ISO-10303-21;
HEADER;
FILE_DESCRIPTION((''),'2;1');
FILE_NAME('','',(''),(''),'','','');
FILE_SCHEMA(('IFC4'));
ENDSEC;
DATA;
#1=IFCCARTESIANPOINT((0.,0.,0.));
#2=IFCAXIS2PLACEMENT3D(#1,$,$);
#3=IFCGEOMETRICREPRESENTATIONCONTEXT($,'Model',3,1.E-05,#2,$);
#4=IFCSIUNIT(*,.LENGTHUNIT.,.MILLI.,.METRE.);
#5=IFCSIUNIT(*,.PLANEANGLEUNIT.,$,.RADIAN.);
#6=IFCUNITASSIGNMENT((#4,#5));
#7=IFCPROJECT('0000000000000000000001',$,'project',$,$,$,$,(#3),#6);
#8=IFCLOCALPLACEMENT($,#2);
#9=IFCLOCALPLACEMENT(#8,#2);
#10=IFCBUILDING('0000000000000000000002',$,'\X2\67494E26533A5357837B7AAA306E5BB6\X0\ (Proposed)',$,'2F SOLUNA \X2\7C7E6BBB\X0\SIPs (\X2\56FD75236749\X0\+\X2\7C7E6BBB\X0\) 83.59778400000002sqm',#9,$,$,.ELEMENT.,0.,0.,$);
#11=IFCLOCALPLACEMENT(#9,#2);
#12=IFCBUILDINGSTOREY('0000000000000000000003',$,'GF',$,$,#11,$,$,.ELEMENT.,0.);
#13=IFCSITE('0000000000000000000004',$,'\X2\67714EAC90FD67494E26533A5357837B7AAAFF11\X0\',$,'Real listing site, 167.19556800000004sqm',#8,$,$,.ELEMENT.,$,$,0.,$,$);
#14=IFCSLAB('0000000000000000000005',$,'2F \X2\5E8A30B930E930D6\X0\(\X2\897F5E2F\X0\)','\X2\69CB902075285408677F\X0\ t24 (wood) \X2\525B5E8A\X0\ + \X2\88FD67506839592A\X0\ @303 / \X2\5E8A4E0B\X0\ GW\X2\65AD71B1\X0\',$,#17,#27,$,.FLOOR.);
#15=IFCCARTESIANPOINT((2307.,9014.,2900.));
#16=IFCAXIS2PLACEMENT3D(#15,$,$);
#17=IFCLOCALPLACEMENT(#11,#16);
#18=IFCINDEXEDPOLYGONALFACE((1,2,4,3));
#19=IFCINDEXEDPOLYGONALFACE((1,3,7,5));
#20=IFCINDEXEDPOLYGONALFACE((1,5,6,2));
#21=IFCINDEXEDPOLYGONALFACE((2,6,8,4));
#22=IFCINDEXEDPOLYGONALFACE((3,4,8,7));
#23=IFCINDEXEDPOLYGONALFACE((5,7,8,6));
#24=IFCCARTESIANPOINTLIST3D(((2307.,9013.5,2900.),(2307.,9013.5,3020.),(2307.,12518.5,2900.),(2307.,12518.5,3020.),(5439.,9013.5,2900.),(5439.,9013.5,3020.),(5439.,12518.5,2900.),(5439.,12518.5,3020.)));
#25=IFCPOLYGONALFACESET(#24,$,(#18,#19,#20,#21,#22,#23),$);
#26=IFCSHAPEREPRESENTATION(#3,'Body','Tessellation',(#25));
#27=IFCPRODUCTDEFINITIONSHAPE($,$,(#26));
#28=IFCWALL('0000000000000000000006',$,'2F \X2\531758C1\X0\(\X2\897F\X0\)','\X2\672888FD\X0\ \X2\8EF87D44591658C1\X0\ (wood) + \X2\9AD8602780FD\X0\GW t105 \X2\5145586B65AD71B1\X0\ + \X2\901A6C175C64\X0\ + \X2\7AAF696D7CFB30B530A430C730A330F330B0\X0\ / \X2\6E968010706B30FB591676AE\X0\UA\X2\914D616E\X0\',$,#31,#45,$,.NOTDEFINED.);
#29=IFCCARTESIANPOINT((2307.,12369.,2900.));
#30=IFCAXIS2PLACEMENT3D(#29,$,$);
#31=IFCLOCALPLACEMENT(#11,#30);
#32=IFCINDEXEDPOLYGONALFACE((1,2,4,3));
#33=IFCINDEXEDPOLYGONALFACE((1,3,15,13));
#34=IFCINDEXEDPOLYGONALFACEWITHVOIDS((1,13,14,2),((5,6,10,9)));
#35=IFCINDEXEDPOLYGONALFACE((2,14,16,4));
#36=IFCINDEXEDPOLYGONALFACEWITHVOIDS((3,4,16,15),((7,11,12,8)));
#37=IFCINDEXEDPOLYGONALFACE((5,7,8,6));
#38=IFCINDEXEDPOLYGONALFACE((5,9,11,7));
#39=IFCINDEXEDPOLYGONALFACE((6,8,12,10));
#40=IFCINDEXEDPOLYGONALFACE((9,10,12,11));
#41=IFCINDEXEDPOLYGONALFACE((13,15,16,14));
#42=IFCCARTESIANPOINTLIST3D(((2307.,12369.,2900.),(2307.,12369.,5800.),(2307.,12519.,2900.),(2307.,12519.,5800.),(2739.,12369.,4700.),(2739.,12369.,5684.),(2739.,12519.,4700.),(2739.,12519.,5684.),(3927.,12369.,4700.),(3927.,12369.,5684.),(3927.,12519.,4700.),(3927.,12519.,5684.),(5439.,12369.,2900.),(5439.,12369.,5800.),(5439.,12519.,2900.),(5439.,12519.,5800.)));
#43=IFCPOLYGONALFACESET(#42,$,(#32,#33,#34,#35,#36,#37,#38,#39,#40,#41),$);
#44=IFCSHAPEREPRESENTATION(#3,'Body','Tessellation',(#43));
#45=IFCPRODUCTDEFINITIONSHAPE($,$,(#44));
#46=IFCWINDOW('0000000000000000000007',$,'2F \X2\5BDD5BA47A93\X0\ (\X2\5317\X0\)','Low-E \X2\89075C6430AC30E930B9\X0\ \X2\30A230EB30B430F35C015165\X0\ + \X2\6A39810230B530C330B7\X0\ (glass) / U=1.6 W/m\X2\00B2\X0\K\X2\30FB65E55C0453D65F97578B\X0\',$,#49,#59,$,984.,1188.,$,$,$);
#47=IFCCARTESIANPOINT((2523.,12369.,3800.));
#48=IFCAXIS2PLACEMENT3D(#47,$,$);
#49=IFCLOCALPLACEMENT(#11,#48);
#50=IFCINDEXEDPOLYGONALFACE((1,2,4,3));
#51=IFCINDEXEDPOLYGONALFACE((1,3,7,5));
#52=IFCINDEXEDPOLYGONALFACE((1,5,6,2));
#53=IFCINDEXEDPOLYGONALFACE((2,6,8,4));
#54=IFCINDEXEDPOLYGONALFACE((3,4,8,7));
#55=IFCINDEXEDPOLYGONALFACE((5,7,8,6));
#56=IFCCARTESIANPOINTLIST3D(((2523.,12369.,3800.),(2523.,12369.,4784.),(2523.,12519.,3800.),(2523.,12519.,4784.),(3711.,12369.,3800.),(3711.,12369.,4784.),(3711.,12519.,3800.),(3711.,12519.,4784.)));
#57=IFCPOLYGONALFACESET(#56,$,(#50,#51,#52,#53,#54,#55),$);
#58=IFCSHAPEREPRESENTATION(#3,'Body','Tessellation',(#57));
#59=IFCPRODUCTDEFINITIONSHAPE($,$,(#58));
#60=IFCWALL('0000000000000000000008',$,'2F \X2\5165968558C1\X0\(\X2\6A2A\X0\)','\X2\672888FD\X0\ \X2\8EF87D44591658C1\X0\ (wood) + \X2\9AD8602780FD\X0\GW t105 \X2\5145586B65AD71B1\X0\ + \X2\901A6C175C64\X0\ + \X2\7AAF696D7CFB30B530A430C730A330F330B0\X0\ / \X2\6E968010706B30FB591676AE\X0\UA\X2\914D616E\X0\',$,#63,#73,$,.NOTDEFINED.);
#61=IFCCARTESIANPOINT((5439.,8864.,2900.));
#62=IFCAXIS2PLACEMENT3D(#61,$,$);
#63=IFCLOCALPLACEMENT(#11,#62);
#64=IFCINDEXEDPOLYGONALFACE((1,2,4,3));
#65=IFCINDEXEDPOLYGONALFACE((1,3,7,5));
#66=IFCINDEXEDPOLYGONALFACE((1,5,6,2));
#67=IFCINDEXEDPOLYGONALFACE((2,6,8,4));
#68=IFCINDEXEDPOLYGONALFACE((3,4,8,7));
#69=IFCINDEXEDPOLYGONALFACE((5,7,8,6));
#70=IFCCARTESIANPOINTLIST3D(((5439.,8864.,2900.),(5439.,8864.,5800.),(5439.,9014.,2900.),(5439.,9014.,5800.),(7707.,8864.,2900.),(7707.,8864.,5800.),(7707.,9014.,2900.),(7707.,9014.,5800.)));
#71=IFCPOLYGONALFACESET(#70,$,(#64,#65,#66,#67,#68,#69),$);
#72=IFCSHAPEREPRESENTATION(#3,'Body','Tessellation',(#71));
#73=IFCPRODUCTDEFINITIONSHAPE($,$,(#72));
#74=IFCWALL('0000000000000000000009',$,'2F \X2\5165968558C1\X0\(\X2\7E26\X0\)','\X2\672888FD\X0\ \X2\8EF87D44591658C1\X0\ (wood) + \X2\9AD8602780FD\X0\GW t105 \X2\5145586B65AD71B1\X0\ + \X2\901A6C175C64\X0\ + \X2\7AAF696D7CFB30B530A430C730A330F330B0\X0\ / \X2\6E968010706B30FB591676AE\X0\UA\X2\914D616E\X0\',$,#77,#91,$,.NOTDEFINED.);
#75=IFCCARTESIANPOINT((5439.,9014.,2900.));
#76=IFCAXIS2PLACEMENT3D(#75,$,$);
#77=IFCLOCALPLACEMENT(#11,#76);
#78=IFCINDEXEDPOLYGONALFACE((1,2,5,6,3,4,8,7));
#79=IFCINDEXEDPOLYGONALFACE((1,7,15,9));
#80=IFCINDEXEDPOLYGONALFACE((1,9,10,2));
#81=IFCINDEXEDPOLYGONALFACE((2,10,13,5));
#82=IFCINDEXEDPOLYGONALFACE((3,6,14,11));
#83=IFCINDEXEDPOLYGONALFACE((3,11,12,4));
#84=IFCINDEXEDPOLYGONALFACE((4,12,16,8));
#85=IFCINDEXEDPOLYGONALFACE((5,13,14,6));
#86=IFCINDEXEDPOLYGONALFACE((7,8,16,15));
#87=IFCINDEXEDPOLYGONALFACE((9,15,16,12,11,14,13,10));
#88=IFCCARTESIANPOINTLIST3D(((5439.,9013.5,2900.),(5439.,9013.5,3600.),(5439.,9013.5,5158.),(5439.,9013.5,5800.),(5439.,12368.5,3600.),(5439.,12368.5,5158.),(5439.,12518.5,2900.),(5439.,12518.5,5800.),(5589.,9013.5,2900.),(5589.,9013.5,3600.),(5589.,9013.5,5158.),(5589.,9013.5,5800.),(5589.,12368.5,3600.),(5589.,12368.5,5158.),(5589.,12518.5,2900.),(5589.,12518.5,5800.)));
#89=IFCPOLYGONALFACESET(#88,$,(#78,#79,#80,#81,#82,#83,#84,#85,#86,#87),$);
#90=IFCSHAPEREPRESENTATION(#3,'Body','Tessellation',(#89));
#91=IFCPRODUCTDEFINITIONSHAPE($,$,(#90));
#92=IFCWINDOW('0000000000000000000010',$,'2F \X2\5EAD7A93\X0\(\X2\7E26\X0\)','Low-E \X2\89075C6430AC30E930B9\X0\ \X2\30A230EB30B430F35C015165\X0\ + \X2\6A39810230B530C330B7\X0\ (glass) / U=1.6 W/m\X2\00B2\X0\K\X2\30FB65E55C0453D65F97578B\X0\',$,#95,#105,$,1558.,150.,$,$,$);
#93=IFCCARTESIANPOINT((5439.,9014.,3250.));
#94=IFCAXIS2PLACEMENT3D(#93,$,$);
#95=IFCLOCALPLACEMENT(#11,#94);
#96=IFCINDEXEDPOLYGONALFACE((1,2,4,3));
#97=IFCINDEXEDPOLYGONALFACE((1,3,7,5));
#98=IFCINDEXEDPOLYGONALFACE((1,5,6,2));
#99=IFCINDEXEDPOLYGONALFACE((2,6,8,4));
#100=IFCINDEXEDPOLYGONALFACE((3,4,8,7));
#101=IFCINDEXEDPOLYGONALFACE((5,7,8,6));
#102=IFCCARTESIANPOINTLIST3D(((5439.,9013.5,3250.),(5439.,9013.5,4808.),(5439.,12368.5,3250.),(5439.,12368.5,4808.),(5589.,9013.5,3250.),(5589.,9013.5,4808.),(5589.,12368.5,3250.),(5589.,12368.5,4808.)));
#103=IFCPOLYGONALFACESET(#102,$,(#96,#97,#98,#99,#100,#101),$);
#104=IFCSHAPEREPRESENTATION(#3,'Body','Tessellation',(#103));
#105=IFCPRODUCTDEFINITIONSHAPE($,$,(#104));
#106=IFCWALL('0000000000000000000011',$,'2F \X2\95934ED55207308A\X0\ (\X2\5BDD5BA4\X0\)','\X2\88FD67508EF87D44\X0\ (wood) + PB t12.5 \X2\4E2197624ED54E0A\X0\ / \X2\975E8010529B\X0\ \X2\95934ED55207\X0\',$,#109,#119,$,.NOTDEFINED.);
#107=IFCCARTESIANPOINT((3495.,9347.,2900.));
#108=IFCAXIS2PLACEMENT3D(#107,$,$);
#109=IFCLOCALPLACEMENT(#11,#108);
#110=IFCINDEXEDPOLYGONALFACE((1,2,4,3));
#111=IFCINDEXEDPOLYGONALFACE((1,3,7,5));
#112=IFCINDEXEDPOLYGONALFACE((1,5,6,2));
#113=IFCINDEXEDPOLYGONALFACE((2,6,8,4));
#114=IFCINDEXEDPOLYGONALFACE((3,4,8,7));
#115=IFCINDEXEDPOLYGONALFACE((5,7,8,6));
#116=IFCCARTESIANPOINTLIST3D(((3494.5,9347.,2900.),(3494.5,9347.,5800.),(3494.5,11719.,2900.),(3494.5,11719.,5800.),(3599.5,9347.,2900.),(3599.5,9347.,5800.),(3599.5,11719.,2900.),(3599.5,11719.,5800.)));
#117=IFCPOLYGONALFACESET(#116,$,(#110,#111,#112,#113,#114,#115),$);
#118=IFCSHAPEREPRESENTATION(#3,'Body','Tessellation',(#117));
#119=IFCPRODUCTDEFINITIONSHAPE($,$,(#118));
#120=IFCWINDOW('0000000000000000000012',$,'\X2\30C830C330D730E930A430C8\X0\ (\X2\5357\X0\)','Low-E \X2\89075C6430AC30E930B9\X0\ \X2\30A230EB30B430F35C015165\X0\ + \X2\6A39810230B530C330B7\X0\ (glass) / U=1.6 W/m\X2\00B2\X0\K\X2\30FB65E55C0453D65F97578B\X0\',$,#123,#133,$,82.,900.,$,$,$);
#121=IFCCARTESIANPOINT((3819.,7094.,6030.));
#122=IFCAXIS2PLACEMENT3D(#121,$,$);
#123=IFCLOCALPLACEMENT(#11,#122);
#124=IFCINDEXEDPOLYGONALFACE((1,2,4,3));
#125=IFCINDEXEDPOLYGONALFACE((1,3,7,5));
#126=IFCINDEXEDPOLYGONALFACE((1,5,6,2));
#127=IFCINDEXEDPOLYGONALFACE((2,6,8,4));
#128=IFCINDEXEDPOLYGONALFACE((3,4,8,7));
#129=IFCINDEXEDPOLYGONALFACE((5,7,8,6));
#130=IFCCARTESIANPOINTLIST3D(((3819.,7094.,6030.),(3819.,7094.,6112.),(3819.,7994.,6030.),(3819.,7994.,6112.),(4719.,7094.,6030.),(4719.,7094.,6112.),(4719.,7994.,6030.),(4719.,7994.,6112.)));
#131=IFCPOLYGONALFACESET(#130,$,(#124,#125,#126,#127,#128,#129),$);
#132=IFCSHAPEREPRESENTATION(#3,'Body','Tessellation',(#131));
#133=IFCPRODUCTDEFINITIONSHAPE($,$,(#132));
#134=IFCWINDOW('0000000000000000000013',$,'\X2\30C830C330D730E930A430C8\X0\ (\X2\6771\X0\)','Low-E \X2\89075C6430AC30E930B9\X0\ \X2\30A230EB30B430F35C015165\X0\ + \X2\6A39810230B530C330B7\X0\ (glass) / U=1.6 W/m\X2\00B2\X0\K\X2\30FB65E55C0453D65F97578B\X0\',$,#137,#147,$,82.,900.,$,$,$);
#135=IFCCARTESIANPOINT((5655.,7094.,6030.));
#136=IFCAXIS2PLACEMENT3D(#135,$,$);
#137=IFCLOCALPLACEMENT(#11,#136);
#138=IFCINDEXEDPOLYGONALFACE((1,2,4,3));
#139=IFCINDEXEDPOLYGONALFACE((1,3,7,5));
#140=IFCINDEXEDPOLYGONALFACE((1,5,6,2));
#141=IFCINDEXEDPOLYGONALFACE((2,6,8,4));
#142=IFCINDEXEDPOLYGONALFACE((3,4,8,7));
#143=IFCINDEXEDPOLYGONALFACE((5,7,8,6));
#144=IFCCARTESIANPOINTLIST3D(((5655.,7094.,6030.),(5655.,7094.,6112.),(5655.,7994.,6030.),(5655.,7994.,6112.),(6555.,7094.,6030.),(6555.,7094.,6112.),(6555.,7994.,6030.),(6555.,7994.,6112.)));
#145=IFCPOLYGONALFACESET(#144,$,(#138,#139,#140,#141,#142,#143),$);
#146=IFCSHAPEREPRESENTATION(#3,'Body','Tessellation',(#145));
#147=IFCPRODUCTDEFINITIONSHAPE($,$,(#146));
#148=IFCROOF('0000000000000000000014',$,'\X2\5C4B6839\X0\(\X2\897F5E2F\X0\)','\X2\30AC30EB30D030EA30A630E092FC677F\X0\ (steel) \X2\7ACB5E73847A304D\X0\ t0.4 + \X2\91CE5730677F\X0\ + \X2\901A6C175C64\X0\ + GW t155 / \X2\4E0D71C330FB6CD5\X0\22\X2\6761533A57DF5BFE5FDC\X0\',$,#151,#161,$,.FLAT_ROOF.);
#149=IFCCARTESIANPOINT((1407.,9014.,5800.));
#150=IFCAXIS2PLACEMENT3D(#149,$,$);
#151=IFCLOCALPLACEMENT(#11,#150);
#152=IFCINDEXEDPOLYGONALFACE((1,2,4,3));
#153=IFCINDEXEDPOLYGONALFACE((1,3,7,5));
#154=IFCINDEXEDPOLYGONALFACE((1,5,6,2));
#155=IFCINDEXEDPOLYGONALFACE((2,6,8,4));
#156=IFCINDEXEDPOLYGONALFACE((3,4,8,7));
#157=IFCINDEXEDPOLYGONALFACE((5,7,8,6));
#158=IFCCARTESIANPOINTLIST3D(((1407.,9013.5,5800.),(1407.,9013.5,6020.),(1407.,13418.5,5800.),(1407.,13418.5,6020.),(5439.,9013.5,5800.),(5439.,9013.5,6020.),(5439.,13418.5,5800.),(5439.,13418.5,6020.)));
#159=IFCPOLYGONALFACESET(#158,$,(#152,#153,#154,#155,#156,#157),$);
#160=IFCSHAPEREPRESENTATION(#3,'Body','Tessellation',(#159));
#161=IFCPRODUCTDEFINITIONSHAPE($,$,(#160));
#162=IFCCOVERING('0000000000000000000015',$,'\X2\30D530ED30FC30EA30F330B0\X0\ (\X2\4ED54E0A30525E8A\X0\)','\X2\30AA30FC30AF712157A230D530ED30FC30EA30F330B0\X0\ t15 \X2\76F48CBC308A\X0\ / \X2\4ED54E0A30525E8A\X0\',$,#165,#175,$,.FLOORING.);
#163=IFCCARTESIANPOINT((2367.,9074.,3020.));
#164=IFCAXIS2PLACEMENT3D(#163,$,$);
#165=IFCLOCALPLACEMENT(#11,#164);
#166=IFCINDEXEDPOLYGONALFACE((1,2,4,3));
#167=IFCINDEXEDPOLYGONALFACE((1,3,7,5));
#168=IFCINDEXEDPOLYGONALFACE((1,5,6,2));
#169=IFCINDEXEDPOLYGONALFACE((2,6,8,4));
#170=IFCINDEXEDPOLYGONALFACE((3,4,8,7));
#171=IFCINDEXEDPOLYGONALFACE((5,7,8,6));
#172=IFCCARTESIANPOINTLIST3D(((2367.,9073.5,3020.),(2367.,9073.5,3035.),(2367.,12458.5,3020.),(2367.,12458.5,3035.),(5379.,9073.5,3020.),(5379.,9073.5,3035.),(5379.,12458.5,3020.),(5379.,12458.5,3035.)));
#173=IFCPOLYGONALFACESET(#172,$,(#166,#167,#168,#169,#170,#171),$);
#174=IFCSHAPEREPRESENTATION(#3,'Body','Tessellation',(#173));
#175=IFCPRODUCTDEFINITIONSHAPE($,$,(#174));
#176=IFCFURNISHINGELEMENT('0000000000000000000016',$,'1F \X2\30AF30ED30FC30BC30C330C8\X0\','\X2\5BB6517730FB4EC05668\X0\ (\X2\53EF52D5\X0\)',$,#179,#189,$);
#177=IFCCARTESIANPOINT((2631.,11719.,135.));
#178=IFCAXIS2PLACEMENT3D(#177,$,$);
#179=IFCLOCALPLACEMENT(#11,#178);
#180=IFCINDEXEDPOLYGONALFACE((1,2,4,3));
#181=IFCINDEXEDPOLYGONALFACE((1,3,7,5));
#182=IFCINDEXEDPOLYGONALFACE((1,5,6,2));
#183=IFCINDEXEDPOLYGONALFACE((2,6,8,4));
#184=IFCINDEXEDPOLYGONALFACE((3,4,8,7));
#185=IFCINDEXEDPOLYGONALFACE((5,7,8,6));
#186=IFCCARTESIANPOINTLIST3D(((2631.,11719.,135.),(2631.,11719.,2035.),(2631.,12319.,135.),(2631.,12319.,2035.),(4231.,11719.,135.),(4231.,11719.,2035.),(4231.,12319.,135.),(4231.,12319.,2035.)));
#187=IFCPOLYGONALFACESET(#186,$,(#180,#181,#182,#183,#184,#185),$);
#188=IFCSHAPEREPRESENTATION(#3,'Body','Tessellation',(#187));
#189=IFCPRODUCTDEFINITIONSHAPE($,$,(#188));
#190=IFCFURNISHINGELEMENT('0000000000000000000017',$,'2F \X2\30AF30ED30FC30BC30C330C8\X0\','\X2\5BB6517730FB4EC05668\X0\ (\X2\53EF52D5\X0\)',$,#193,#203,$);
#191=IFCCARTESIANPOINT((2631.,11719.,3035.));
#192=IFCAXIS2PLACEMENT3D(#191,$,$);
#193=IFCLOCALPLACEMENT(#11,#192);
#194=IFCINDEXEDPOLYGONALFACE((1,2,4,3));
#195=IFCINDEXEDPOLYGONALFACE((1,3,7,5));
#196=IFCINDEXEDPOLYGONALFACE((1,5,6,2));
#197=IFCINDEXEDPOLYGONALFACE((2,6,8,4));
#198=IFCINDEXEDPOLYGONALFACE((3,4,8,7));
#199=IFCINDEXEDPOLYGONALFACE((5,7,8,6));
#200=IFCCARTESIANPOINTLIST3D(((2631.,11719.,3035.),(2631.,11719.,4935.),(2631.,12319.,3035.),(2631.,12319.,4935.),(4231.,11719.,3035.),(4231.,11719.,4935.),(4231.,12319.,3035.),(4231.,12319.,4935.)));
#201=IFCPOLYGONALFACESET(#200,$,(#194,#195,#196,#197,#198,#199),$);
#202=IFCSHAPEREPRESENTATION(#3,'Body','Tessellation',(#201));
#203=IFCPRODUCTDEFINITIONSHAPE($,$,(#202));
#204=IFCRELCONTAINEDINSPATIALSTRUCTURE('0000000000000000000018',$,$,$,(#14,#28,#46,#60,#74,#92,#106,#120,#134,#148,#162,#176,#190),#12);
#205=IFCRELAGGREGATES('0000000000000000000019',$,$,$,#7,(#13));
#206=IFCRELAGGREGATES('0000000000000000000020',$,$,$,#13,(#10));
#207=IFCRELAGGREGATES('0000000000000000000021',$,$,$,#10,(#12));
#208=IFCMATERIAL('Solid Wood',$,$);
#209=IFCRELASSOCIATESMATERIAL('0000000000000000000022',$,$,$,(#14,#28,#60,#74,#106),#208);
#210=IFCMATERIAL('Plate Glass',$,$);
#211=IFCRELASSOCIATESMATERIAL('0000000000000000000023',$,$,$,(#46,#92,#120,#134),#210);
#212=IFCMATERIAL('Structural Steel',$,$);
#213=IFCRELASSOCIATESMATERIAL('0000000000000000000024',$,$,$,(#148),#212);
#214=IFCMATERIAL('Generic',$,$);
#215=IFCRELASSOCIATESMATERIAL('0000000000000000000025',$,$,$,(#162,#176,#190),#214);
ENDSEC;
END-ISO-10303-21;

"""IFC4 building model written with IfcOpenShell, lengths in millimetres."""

from ifc_helpers import new_model, si_unit, frame, frame_2d, origin, place, context, project, spatial, rectangle, extrude, material, element, fill, save


model = new_model("IFC4")

# Units and contexts
model_context = context("Model", 3, precision=1e-05, world=origin())
ifc_project = project(units=[si_unit("LENGTHUNIT", "METRE", prefix="MILLI"), si_unit("PLANEANGLEUNIT", "RADIAN")], contexts=[model_context])

# Site, building, storey
site_placement = place(None, origin())
site = spatial("IfcSite", under=ifc_project, at=site_placement, Name="東京都杉並区南荻窪１", ObjectType="Real listing site, 167.19556800000004sqm", CompositionType="ELEMENT", RefElevation=0.0)
building_placement = place(site_placement, origin())
building = spatial("IfcBuilding", under=site, at=building_placement, Name="杉並区南荻窪の家 (Proposed)", ObjectType="2F SOLUNA 籾殻SIPs (国産杉+籾殻) 83.59778400000002sqm", CompositionType="ELEMENT", ElevationOfRefHeight=0.0, ElevationOfTerrain=0.0)
storey_placement = place(building_placement, origin())
storey = spatial("IfcBuildingStorey", under=building, at=storey_placement, Name="GF", CompositionType="ELEMENT", Elevation=0.0)

# Slab
ifc_material_1 = material(Name="Solid Wood")
slab_placement = place(storey_placement, frame((2307.0, 9014.0, 2900.0)))
element("IfcSlab", 1, at=slab_placement, inside=storey, material=ifc_material_1, Name="2F 床スラブ(西帯)", Description="構造用合板 t24 (wood) 剛床 + 製材根太 @303 / 床下 GW断熱", PredefinedType="FLOOR", context=model_context, shape_type="SweptSolid", body=[
    extrude(rectangle(XDim=3132.0, YDim=3505.0, at=frame_2d((1566.0, 1752.0))), frame((2307.0, 9014.0, 2900.0)), (0.0, 0.0, 1.0), 120.0),
])

# Wall, opening, window
wall_1_placement = place(storey_placement, frame((2307.0, 12369.0, 2900.0)))
wall_1 = element("IfcWall", 2, at=wall_1_placement, inside=storey, material=ifc_material_1, Name="2F 北壁(西)", Description="木製 軸組外壁 (wood) + 高性能GW t105 充填断熱 + 通気層 + 窯業系サイディング / 準耐火・外皮UA配慮", PredefinedType="NOTDEFINED", context=model_context, shape_type="SweptSolid", body=[
    extrude(rectangle(XDim=3132.0, YDim=150.0, at=frame_2d((1566.0, 75.0))), frame((2307.0, 12369.0, 2900.0)), (0.0, 0.0, 1.0), 2900.0),
])
opening_1_placement = place(storey_placement, frame((2523.0, 12369.0, 3800.0)))
opening_1 = element("IfcOpeningElement", 3, at=opening_1_placement, cuts=wall_1, PredefinedType="NOTDEFINED", context=model_context, shape_type="SweptSolid", body=[
    extrude(rectangle(XDim=1188.0, YDim=150.0, at=frame_2d((594.0, 75.0))), frame((2523.0, 12369.0, 3800.0)), (0.0, 0.0, 1.0), 984.0),
])
ifc_material_2 = material(Name="Plate Glass")
window_1_placement = place(storey_placement, frame((2523.0, 12369.0, 3800.0)))
window_1 = element("IfcWindow", 4, at=window_1_placement, inside=storey, material=ifc_material_2, Name="2F 寝室窓 (北)", Description="Low-E 複層ガラス アルゴン封入 + 樹脂サッシ (glass) / U=1.6 W/m²K・日射取得型", OverallHeight=984.0, OverallWidth=1188.0, context=model_context, shape_type="SweptSolid", body=[
    extrude(rectangle(XDim=1188.0, YDim=150.0, at=frame_2d((594.0, 75.0))), frame((2523.0, 12369.0, 3800.0)), (0.0, 0.0, 1.0), 984.0),
])
fill(opening_1, window_1)

# Wall
wall_2_placement = place(storey_placement, frame((5439.0, 8864.0, 2900.0)))
element("IfcWall", 5, at=wall_2_placement, inside=storey, material=ifc_material_1, Name="2F 入隅壁(横)", Description="木製 軸組外壁 (wood) + 高性能GW t105 充填断熱 + 通気層 + 窯業系サイディング / 準耐火・外皮UA配慮", PredefinedType="NOTDEFINED", context=model_context, shape_type="SweptSolid", body=[
    extrude(rectangle(XDim=2268.0, YDim=150.0, at=frame_2d((1134.0, 75.0))), frame((5439.0, 8864.0, 2900.0)), (0.0, 0.0, 1.0), 2900.0),
])

# Wall, opening, window
wall_3_placement = place(storey_placement, frame((5439.0, 9014.0, 2900.0)))
wall_3 = element("IfcWall", 6, at=wall_3_placement, inside=storey, material=ifc_material_1, Name="2F 入隅壁(縦)", Description="木製 軸組外壁 (wood) + 高性能GW t105 充填断熱 + 通気層 + 窯業系サイディング / 準耐火・外皮UA配慮", PredefinedType="NOTDEFINED", context=model_context, shape_type="SweptSolid", body=[
    extrude(rectangle(XDim=150.0, YDim=3505.0, at=frame_2d((75.0, 1752.0))), frame((5439.0, 9014.0, 2900.0)), (0.0, 0.0, 1.0), 2900.0),
])
opening_2_placement = place(storey_placement, frame((5439.0, 9014.0, 3250.0)))
opening_2 = element("IfcOpeningElement", 7, at=opening_2_placement, cuts=wall_3, PredefinedType="NOTDEFINED", context=model_context, shape_type="SweptSolid", body=[
    extrude(rectangle(XDim=150.0, YDim=3355.0, at=frame_2d((75.0, 1677.0))), frame((5439.0, 9014.0, 3250.0)), (0.0, 0.0, 1.0), 1558.0),
])
window_2_placement = place(storey_placement, frame((5439.0, 9014.0, 3250.0)))
window_2 = element("IfcWindow", 8, at=window_2_placement, inside=storey, material=ifc_material_2, Name="2F 庭窓(縦)", Description="Low-E 複層ガラス アルゴン封入 + 樹脂サッシ (glass) / U=1.6 W/m²K・日射取得型", OverallHeight=1558.0, OverallWidth=150.0, context=model_context, shape_type="SweptSolid", body=[
    extrude(rectangle(XDim=150.0, YDim=3355.0, at=frame_2d((75.0, 1677.0))), frame((5439.0, 9014.0, 3250.0)), (0.0, 0.0, 1.0), 1558.0),
])
fill(opening_2, window_2)

# Wall
wall_4_placement = place(storey_placement, frame((3495.0, 9347.0, 2900.0)))
element("IfcWall", 9, at=wall_4_placement, inside=storey, material=ifc_material_1, Name="2F 間仕切り (寝室)", Description="製材軸組 (wood) + PB t12.5 両面仕上 / 非耐力 間仕切", PredefinedType="NOTDEFINED", context=model_context, shape_type="SweptSolid", body=[
    extrude(rectangle(XDim=105.0, YDim=2372.0, at=frame_2d((52.0, 1186.0))), frame((3495.0, 9347.0, 2900.0)), (0.0, 0.0, 1.0), 2900.0),
])

# Windows
window_3_placement = place(storey_placement, frame((3819.0, 7094.0, 6030.0)))
element("IfcWindow", 10, at=window_3_placement, inside=storey, material=ifc_material_2, Name="トップライト (南)", Description="Low-E 複層ガラス アルゴン封入 + 樹脂サッシ (glass) / U=1.6 W/m²K・日射取得型", OverallHeight=82.0, OverallWidth=900.0, context=model_context, shape_type="SweptSolid", body=[
    extrude(rectangle(XDim=900.0, YDim=900.0, at=frame_2d((450.0, 450.0))), frame((3819.0, 7094.0, 6030.0)), (0.0, 0.0, 1.0), 82.0),
])
window_4_placement = place(storey_placement, frame((5655.0, 7094.0, 6030.0)))
element("IfcWindow", 11, at=window_4_placement, inside=storey, material=ifc_material_2, Name="トップライト (東)", Description="Low-E 複層ガラス アルゴン封入 + 樹脂サッシ (glass) / U=1.6 W/m²K・日射取得型", OverallHeight=82.0, OverallWidth=900.0, context=model_context, shape_type="SweptSolid", body=[
    extrude(rectangle(XDim=900.0, YDim=900.0, at=frame_2d((450.0, 450.0))), frame((5655.0, 7094.0, 6030.0)), (0.0, 0.0, 1.0), 82.0),
])

# Roof
ifc_material_3 = material(Name="Structural Steel")
for number, where, name in (
    (12, (1407.0, 9014.0, 5800.0), "屋根(西帯)"),
):
    element("IfcRoof", number, at=place(storey_placement, frame(where)), inside=storey, material=ifc_material_3, Name=name, Description="ガルバリウム鋼板 (steel) 立平葺き t0.4 + 野地板 + 通気層 + GW t155 / 不燃・法22条区域対応", PredefinedType="FLAT_ROOF", context=model_context, shape_type="SweptSolid", body=[
        extrude(rectangle(XDim=4032.0, YDim=4405.0, at=frame_2d((2016.0, 2202.0))), frame((1407.0, 9014.0, 5800.0)), (0.0, 0.0, 1.0), 220.0),
    ])

# Covering
ifc_material_4 = material(Name="Generic")
covering_placement = place(storey_placement, frame((2367.0, 9074.0, 3020.0)))
element("IfcCovering", 13, at=covering_placement, inside=storey, material=ifc_material_4, Name="フローリング (仕上げ床)", Description="オーク無垢フローリング t15 直貼り / 仕上げ床", PredefinedType="FLOORING", context=model_context, shape_type="SweptSolid", body=[
    extrude(rectangle(XDim=3012.0, YDim=3385.0, at=frame_2d((1506.0, 1692.0))), frame((2367.0, 9074.0, 3020.0)), (0.0, 0.0, 1.0), 15.0),
])

# Furnishing elements
furnishing_1_placement = place(storey_placement, frame((2631.0, 11719.0, 135.0)))
element("IfcFurnishingElement", 14, at=furnishing_1_placement, inside=storey, material=ifc_material_4, Name="1F クローゼット", Description="家具・什器 (可動)", context=model_context, shape_type="SweptSolid", body=[
    extrude(rectangle(XDim=1600.0, YDim=600.0, at=frame_2d((800.0, 300.0))), frame((2631.0, 11719.0, 135.0)), (0.0, 0.0, 1.0), 1900.0),
])
furnishing_2_placement = place(storey_placement, frame((2631.0, 11719.0, 3035.0)))
element("IfcFurnishingElement", 15, at=furnishing_2_placement, inside=storey, material=ifc_material_4, Name="2F クローゼット", Description="家具・什器 (可動)", context=model_context, shape_type="SweptSolid", body=[
    extrude(rectangle(XDim=1600.0, YDim=600.0, at=frame_2d((800.0, 300.0))), frame((2631.0, 11719.0, 3035.0)), (0.0, 0.0, 1.0), 1900.0),
])

save(model, "model.ifc")
